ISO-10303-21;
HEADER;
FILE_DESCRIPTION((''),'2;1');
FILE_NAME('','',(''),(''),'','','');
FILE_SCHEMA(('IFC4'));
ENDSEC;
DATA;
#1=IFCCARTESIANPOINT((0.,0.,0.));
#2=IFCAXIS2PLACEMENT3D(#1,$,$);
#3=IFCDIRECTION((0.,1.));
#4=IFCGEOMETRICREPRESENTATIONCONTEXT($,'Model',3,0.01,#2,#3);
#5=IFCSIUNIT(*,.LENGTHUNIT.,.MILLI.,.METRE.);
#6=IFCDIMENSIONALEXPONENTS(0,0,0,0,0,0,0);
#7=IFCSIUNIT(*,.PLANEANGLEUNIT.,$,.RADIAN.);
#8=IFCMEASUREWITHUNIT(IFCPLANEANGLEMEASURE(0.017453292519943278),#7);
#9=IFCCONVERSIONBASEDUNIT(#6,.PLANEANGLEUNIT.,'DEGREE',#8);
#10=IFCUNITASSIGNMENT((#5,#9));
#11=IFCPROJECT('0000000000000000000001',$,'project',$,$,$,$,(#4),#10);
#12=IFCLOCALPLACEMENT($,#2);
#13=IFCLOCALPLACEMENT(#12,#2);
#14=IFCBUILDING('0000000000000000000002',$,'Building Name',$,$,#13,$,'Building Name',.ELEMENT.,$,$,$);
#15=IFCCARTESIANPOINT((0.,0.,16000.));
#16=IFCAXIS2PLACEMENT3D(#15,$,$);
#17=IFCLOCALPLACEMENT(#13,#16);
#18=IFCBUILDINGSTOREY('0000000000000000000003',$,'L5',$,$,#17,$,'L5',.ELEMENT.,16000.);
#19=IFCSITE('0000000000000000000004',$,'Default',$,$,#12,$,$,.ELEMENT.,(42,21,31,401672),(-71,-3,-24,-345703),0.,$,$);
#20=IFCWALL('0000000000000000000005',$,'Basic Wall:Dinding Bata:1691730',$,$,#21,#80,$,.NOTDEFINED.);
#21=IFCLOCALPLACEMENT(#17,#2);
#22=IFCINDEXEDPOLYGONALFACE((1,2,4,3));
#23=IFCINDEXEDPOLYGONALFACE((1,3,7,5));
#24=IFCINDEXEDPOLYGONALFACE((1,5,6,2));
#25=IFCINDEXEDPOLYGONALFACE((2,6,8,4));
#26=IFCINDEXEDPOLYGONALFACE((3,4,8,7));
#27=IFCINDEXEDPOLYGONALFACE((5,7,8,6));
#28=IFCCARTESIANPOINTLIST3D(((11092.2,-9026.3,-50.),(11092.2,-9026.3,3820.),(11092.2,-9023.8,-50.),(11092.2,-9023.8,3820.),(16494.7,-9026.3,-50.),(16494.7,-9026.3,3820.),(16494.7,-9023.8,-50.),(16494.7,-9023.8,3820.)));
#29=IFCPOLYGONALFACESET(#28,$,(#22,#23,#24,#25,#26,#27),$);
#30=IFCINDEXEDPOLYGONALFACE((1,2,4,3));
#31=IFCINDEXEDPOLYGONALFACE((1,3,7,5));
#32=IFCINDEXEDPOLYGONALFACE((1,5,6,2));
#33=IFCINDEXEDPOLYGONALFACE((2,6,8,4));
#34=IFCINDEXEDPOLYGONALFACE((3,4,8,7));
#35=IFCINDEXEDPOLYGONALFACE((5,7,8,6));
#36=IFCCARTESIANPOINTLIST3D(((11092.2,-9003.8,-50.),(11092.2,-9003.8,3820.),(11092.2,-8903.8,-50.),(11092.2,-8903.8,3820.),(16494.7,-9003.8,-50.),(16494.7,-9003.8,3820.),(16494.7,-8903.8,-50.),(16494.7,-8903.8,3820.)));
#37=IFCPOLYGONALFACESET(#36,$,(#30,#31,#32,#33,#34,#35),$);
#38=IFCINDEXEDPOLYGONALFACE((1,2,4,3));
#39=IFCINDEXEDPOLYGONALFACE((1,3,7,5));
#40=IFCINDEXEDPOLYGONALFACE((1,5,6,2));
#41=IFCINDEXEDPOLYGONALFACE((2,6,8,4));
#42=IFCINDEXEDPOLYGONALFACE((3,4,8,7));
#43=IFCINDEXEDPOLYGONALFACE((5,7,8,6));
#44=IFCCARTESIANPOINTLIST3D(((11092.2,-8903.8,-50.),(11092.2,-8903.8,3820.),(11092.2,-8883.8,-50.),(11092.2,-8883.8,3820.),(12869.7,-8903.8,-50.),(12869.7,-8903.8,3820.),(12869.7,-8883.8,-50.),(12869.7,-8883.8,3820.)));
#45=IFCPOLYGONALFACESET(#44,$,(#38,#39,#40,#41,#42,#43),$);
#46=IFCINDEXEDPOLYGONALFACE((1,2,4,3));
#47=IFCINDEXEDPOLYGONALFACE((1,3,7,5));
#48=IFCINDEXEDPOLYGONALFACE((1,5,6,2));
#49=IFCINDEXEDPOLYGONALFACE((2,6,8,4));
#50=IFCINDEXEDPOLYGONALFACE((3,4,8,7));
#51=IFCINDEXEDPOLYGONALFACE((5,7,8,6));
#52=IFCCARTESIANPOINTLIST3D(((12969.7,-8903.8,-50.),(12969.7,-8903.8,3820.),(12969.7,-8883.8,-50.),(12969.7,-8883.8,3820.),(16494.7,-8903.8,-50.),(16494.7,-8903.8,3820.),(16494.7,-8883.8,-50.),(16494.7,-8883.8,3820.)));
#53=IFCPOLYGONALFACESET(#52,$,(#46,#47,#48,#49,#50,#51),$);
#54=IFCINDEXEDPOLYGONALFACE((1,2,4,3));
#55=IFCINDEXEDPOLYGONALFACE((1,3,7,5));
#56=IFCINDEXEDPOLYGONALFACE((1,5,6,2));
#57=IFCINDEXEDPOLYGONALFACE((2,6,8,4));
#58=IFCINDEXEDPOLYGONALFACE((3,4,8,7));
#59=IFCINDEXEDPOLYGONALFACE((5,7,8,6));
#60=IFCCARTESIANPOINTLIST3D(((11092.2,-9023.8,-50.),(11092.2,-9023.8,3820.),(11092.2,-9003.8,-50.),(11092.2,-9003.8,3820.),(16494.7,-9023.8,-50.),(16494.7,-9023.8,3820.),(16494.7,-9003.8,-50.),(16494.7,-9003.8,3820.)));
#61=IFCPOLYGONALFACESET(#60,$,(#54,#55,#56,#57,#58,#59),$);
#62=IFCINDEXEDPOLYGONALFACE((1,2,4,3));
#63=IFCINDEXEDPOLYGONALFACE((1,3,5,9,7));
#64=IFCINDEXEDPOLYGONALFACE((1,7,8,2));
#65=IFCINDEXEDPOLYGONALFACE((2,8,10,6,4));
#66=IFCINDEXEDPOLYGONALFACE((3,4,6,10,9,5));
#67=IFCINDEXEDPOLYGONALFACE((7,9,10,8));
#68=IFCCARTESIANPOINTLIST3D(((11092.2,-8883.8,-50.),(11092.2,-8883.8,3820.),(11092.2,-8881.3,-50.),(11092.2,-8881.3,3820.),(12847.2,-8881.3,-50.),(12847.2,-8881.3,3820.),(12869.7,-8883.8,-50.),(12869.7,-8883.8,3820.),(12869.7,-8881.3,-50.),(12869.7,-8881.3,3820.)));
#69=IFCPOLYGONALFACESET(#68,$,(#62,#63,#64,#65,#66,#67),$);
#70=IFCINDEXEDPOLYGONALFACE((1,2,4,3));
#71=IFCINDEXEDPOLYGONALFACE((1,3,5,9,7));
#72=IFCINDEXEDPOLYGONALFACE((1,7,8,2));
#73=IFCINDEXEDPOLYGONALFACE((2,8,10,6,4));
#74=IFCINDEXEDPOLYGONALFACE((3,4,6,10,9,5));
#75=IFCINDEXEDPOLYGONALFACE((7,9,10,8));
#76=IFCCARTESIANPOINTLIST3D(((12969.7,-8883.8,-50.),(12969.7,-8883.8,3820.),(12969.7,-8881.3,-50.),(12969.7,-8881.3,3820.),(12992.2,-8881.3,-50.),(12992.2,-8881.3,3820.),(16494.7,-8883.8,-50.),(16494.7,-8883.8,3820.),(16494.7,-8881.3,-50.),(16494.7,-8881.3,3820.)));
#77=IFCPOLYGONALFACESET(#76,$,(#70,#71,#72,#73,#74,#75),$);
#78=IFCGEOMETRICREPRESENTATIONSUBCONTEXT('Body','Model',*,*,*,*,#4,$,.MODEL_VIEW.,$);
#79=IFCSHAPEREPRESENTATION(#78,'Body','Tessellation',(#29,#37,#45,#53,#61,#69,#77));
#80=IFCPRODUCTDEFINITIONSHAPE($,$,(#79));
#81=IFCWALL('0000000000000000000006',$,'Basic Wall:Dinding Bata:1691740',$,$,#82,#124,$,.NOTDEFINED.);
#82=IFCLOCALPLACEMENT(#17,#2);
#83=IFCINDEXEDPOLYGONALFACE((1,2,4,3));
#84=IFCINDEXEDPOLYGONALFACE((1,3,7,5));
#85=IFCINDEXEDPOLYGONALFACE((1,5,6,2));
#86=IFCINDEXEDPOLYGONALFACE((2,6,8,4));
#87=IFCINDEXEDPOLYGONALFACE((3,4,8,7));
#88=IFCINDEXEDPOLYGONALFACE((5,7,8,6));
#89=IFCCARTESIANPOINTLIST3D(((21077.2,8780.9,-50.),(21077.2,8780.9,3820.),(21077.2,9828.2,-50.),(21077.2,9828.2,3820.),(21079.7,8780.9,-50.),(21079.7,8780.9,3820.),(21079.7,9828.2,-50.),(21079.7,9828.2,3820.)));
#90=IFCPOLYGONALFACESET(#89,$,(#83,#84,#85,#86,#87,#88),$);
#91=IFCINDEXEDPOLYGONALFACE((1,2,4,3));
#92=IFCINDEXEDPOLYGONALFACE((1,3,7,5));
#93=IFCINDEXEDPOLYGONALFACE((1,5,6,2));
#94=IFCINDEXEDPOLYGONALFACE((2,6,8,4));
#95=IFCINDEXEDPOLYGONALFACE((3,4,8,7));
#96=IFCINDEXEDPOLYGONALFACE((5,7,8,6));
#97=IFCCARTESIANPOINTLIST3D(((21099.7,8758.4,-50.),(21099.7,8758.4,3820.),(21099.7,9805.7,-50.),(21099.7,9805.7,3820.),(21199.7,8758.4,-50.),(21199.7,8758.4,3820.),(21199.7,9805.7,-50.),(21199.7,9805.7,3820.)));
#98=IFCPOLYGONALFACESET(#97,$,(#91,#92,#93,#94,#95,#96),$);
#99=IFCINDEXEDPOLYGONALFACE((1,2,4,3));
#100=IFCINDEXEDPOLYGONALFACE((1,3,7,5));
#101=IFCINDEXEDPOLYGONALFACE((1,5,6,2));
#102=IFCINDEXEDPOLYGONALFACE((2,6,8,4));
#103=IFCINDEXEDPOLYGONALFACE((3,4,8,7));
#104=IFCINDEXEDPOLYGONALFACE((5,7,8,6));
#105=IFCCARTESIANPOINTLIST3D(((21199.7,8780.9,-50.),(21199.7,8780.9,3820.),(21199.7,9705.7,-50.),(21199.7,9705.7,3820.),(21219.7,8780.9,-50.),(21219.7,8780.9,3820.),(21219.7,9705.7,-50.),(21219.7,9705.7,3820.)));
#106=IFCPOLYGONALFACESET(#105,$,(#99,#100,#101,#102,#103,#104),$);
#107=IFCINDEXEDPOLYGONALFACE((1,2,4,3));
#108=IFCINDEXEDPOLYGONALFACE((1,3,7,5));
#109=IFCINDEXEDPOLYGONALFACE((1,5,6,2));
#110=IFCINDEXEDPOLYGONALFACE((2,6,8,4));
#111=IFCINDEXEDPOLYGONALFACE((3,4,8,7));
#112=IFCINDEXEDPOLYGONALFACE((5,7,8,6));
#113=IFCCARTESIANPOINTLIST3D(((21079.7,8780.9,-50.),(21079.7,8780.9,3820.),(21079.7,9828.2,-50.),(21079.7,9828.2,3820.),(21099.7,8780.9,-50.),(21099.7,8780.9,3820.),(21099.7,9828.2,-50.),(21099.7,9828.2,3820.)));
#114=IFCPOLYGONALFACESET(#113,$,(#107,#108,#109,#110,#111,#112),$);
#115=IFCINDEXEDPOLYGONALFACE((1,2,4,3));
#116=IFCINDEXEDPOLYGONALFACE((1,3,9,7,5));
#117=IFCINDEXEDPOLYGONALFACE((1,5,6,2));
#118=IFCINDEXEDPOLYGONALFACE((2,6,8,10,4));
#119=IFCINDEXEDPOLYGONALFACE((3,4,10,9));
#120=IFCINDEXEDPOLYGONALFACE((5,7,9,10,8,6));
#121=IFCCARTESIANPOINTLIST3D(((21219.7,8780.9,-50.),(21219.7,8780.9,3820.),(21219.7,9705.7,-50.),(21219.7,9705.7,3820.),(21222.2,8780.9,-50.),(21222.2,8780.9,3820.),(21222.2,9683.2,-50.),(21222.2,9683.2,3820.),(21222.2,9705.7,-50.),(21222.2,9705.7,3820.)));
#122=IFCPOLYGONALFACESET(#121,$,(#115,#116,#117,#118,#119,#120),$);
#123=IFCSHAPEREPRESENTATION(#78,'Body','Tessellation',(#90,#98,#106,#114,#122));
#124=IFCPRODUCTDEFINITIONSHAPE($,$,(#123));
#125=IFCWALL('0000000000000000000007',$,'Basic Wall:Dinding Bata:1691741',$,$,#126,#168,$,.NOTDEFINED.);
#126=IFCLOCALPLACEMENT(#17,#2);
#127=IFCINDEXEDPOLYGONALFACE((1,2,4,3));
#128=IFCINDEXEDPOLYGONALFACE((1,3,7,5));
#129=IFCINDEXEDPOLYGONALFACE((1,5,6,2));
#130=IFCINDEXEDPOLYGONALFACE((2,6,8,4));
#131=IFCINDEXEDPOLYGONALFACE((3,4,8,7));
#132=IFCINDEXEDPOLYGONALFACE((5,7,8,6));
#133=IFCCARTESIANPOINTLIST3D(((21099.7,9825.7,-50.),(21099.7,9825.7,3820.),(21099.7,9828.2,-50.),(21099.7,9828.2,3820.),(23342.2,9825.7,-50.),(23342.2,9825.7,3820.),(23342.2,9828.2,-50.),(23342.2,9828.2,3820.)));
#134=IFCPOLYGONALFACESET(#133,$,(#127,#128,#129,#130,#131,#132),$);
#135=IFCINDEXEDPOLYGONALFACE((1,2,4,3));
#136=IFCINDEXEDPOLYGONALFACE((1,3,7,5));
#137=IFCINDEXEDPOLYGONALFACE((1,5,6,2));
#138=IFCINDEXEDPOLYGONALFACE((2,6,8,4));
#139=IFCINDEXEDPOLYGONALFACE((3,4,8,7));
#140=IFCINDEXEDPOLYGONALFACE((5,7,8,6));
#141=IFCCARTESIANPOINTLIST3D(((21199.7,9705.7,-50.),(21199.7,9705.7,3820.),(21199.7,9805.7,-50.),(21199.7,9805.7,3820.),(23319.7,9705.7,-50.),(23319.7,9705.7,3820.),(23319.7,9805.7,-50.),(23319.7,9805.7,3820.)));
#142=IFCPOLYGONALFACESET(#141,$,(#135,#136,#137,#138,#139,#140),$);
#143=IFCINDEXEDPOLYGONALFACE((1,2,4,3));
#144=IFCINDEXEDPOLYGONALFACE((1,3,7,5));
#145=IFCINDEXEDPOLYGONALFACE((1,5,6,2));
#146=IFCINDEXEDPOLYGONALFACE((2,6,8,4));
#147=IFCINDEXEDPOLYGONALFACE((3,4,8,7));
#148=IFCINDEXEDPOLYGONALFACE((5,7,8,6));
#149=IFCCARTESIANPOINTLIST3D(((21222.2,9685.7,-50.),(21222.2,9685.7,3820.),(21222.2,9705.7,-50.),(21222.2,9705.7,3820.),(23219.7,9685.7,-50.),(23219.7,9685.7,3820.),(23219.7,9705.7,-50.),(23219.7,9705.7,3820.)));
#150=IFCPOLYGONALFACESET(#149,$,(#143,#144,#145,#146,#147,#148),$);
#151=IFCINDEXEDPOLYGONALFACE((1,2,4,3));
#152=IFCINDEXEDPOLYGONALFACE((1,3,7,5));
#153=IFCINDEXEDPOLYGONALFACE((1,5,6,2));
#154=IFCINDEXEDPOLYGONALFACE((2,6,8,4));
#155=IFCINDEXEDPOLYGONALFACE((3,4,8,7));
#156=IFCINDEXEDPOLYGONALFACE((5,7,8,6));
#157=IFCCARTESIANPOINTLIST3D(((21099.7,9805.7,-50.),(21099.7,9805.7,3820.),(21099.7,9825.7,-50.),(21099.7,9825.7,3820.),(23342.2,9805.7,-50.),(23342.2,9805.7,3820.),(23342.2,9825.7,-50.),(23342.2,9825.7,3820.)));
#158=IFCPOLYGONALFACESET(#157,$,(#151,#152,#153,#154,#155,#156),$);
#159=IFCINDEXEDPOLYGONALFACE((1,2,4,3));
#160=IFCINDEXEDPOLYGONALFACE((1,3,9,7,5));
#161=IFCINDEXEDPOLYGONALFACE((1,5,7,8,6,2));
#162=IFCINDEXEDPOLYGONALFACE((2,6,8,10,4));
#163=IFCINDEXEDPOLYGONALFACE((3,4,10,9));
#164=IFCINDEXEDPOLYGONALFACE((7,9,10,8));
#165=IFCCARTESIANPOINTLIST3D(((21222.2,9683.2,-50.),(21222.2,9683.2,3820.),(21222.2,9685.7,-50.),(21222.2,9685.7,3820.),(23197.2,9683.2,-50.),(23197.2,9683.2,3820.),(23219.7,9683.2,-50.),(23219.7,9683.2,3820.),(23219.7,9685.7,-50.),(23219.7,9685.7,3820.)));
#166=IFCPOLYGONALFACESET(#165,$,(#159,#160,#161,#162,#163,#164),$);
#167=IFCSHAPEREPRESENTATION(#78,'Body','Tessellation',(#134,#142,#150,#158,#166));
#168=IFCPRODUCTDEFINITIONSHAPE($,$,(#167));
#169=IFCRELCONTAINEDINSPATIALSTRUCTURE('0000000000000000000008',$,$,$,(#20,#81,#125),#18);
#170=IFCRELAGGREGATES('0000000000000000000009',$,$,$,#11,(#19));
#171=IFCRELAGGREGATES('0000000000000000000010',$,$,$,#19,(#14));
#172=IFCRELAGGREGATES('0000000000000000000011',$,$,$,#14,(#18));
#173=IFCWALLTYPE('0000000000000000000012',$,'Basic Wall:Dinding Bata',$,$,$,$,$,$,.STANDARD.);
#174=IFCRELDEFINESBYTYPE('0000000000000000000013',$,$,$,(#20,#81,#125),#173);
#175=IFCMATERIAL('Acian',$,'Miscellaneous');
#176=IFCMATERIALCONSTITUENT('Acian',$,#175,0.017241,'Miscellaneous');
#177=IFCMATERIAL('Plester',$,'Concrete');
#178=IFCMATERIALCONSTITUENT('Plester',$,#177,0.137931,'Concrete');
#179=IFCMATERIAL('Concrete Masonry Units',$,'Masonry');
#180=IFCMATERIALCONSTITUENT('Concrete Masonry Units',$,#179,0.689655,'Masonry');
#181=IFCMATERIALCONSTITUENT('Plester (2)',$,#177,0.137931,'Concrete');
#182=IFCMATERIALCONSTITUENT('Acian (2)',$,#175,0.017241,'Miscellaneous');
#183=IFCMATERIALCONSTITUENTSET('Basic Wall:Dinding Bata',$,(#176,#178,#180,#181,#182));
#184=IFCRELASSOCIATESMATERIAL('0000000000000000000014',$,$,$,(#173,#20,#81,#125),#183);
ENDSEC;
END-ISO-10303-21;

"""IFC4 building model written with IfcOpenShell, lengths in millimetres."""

from ifc_helpers import new_model, entity, si_unit, converted_unit, direction, frame, origin, place, context, subcontext, project, spatial, indexed_curve, outline, extrude, material, constituent, constituent_set, type_object, element, save


model = new_model("IFC4")

# Units and contexts
model_context = context("Model", 3, precision=0.01, world=origin(), true_north=direction((0.0, 1.0)))
body_context = subcontext(model_context, "Body", "Model", "MODEL_VIEW")
ifc_project = project(units=[si_unit("LENGTHUNIT", "METRE", prefix="MILLI"), converted_unit("PLANEANGLEUNIT", "DEGREE", entity("IfcPlaneAngleMeasure", 0.017453292519943278), si_unit("PLANEANGLEUNIT", "RADIAN"), dimensions=[0, 0, 0, 0, 0, 0, 0])], contexts=[model_context])

# Site, building, storey
site_placement = place(None, origin())
site = spatial("IfcSite", under=ifc_project, at=site_placement, Name="Default", CompositionType="ELEMENT", RefLatitude=(42, 21, 31, 401672), RefLongitude=(-71, -3, -24, -345703), RefElevation=0.0)
building_placement = place(site_placement, origin())
building = spatial("IfcBuilding", under=site, at=building_placement, Name="Building Name", LongName="Building Name", CompositionType="ELEMENT")
storey_placement = place(building_placement, frame((0.0, 0.0, 16000.0)))
storey = spatial("IfcBuildingStorey", under=building, at=storey_placement, Name="L5", LongName="L5", CompositionType="ELEMENT", Elevation=16000.0)

# Walls
ifc_material_1 = material(Name="Acian", Category="Miscellaneous")
ifc_constituent_1 = constituent(ifc_material_1, Name="Acian", Category="Miscellaneous", fraction=0.017241)
ifc_material_2 = material(Name="Plester", Category="Concrete")
ifc_constituent_2 = constituent(ifc_material_2, Name="Plester", Category="Concrete", fraction=0.137931)
ifc_material_3 = material(Name="Concrete Masonry Units", Category="Masonry")
ifc_constituent_3 = constituent(ifc_material_3, Name="Concrete Masonry Units", Category="Masonry", fraction=0.689655)
ifc_constituent_4 = constituent(ifc_material_2, Name="Plester (2)", Category="Concrete", fraction=0.137931)
ifc_constituent_5 = constituent(ifc_material_1, Name="Acian (2)", Category="Miscellaneous", fraction=0.017241)
ifc_constituent_set = constituent_set(constituents=[ifc_constituent_1, ifc_constituent_2, ifc_constituent_3, ifc_constituent_4, ifc_constituent_5], Name="Basic Wall:Dinding Bata")
wall_type = type_object("IfcWallType", Name="Basic Wall:Dinding Bata", PredefinedType="STANDARD", material=ifc_constituent_set)
wall_1_placement = place(storey_placement, frame((16494.7, -8953.8, -50.0), z_axis=(0.0, 0.0, 1.0), x_axis=(-1.0, 0.0, 0.0)))
element("IfcWall", 1, at=wall_1_placement, inside=storey, type_object=wall_type, material=ifc_constituent_set, Name="Basic Wall:Dinding Bata:1691730", PredefinedType="NOTDEFINED", context=body_context, shape_type="SweptSolid", body=[
    extrude(outline(indexed_curve([(-1.3, -2701.2), (1.2, -2701.2), (1.3, 2701.2), (-1.2, 2701.2), (-1.3, -2701.2)], self_intersect=False)), frame((2701.2, 71.3, 0.0), z_axis=(0.0, 0.0, 1.0), x_axis=(0.0, -1.0, 0.0)), (0.0, 0.0, 1.0), 3870.0),
    extrude(outline(indexed_curve([(-2701.2, -50.0), (2701.2, -50.0), (2701.2, 50.0), (-2701.2, 50.0), (-2701.2, -50.0)], self_intersect=False)), frame((2701.2, 0.0, 0.0)), (0.0, 0.0, 1.0), 3870.0),
    extrude(outline(indexed_curve([(-888.7, -10.0), (888.7, -10.0), (888.7, 10.0), (-888.7, 10.0), (-888.7, -10.0)], self_intersect=False)), frame((4513.8, -60.0, 0.0), z_axis=(0.0, 0.0, 1.0), x_axis=(-1.0, 0.0, 0.0)), (0.0, 0.0, 1.0), 3870.0),
    extrude(outline(indexed_curve([(-1762.5, -10.0), (1762.5, -10.0), (1762.5, 10.0), (-1762.5, 10.0), (-1762.5, -10.0)], self_intersect=False)), frame((1762.5, -60.0, 0.0)), (0.0, 0.0, 1.0), 3870.0),
    extrude(outline(indexed_curve([(-2701.2, -10.0), (2701.2, -10.0), (2701.2, 10.0), (-2701.2, 10.0), (-2701.2, -10.0)], self_intersect=False)), frame((2701.2, 60.0, 0.0)), (0.0, 0.0, 1.0), 3870.0),
    extrude(outline(indexed_curve([(-1.0, -1062.0), (1.5, -1062.0), (1.5, 715.5), (-1.0, 715.5), (-1.0, 693.0), (-1.0, -1062.0)], self_intersect=False)), frame((4340.5, -71.5, 0.0), z_axis=(0.0, 0.0, 1.0), x_axis=(0.0, 1.0, 0.0)), (0.0, 0.0, 1.0), 3870.0),
    extrude(outline(indexed_curve([(1392.0, -1.0), (1414.5, -1.0), (1414.5, 1.5), (-2110.5, 1.5), (-2110.5, -1.0), (1392.0, -1.0)], self_intersect=False)), frame((2110.5, -71.5, 0.0)), (0.0, 0.0, 1.0), 3870.0),
])
wall_2_placement = place(storey_placement, frame((21149.7, 8780.9, -50.0), z_axis=(0.0, 0.0, 1.0), x_axis=(0.0, 1.0, 0.0)))
element("IfcWall", 2, at=wall_2_placement, inside=storey, type_object=wall_type, material=ifc_constituent_set, Name="Basic Wall:Dinding Bata:1691740", PredefinedType="NOTDEFINED", context=body_context, shape_type="SweptSolid", body=[
    extrude(outline(indexed_curve([(-1.2, -523.7), (1.2, -523.7), (1.2, 523.7), (-1.2, 523.7), (-1.2, -523.7)], self_intersect=False)), frame((523.7, 71.3, 0.0), z_axis=(0.0, 0.0, 1.0), x_axis=(0.0, -1.0, 0.0)), (0.0, 0.0, 1.0), 3870.0),
    extrude(outline(indexed_curve([(-523.7, -50.0), (523.7, -50.0), (523.7, 50.0), (-523.7, 50.0), (-523.7, -50.0)], self_intersect=False)), frame((501.2, 0.0, 0.0)), (0.0, 0.0, 1.0), 3870.0),
    extrude(outline(indexed_curve([(-462.4, -10.0), (462.4, -10.0), (462.4, 10.0), (-462.4, 10.0), (-462.4, -10.0)], self_intersect=False)), frame((462.4, -60.0, 0.0)), (0.0, 0.0, 1.0), 3870.0),
    extrude(outline(indexed_curve([(-523.7, -10.0), (523.7, -10.0), (523.7, 10.0), (-523.7, 10.0), (-523.7, -10.0)], self_intersect=False)), frame((523.7, 60.0, 0.0)), (0.0, 0.0, 1.0), 3870.0),
    extrude(outline(indexed_curve([(351.9, -1.0), (374.4, -1.0), (374.4, 1.5), (-550.4, 1.5), (-550.4, -1.0), (351.9, -1.0)], self_intersect=False)), frame((550.4, -71.5, 0.0)), (0.0, 0.0, 1.0), 3870.0),
])
wall_3_placement = place(storey_placement, frame((21222.2, 9755.7, -50.0)))
element("IfcWall", 3, at=wall_3_placement, inside=storey, type_object=wall_type, material=ifc_constituent_set, Name="Basic Wall:Dinding Bata:1691741", PredefinedType="NOTDEFINED", context=body_context, shape_type="SweptSolid", body=[
    extrude(outline(indexed_curve([(-1.3, -1121.3), (1.2, -1121.3), (1.3, 1121.3), (-1.2, 1121.3), (-1.3, -1121.3)], self_intersect=False)), frame((998.8, 71.2, 0.0), z_axis=(0.0, 0.0, 1.0), x_axis=(0.0, -1.0, 0.0)), (0.0, 0.0, 1.0), 3870.0),
    extrude(outline(indexed_curve([(-1060.0, -50.0), (1060.0, -50.0), (1060.0, 50.0), (-1060.0, 50.0), (-1060.0, -50.0)], self_intersect=False)), frame((1037.5, 0.0, 0.0)), (0.0, 0.0, 1.0), 3870.0),
    extrude(outline(indexed_curve([(-998.8, -10.0), (998.8, -10.0), (998.8, 10.0), (-998.8, 10.0), (-998.8, -10.0)], self_intersect=False)), frame((998.8, -60.0, 0.0)), (0.0, 0.0, 1.0), 3870.0),
    extrude(outline(indexed_curve([(-1121.3, -10.0), (1121.3, -10.0), (1121.3, 10.0), (-1121.3, 10.0), (-1121.3, -10.0)], self_intersect=False)), frame((998.8, 60.0, 0.0)), (0.0, 0.0, 1.0), 3870.0),
    extrude(outline(indexed_curve([(781.0, -1.0), (803.5, -1.0), (803.5, 1.5), (-1194.0, 1.5), (-1194.0, -1.0), (781.0, -1.0)], self_intersect=False)), frame((1194.0, -71.5, 0.0)), (0.0, 0.0, 1.0), 3870.0),
])

save(model, "model.ifc")
